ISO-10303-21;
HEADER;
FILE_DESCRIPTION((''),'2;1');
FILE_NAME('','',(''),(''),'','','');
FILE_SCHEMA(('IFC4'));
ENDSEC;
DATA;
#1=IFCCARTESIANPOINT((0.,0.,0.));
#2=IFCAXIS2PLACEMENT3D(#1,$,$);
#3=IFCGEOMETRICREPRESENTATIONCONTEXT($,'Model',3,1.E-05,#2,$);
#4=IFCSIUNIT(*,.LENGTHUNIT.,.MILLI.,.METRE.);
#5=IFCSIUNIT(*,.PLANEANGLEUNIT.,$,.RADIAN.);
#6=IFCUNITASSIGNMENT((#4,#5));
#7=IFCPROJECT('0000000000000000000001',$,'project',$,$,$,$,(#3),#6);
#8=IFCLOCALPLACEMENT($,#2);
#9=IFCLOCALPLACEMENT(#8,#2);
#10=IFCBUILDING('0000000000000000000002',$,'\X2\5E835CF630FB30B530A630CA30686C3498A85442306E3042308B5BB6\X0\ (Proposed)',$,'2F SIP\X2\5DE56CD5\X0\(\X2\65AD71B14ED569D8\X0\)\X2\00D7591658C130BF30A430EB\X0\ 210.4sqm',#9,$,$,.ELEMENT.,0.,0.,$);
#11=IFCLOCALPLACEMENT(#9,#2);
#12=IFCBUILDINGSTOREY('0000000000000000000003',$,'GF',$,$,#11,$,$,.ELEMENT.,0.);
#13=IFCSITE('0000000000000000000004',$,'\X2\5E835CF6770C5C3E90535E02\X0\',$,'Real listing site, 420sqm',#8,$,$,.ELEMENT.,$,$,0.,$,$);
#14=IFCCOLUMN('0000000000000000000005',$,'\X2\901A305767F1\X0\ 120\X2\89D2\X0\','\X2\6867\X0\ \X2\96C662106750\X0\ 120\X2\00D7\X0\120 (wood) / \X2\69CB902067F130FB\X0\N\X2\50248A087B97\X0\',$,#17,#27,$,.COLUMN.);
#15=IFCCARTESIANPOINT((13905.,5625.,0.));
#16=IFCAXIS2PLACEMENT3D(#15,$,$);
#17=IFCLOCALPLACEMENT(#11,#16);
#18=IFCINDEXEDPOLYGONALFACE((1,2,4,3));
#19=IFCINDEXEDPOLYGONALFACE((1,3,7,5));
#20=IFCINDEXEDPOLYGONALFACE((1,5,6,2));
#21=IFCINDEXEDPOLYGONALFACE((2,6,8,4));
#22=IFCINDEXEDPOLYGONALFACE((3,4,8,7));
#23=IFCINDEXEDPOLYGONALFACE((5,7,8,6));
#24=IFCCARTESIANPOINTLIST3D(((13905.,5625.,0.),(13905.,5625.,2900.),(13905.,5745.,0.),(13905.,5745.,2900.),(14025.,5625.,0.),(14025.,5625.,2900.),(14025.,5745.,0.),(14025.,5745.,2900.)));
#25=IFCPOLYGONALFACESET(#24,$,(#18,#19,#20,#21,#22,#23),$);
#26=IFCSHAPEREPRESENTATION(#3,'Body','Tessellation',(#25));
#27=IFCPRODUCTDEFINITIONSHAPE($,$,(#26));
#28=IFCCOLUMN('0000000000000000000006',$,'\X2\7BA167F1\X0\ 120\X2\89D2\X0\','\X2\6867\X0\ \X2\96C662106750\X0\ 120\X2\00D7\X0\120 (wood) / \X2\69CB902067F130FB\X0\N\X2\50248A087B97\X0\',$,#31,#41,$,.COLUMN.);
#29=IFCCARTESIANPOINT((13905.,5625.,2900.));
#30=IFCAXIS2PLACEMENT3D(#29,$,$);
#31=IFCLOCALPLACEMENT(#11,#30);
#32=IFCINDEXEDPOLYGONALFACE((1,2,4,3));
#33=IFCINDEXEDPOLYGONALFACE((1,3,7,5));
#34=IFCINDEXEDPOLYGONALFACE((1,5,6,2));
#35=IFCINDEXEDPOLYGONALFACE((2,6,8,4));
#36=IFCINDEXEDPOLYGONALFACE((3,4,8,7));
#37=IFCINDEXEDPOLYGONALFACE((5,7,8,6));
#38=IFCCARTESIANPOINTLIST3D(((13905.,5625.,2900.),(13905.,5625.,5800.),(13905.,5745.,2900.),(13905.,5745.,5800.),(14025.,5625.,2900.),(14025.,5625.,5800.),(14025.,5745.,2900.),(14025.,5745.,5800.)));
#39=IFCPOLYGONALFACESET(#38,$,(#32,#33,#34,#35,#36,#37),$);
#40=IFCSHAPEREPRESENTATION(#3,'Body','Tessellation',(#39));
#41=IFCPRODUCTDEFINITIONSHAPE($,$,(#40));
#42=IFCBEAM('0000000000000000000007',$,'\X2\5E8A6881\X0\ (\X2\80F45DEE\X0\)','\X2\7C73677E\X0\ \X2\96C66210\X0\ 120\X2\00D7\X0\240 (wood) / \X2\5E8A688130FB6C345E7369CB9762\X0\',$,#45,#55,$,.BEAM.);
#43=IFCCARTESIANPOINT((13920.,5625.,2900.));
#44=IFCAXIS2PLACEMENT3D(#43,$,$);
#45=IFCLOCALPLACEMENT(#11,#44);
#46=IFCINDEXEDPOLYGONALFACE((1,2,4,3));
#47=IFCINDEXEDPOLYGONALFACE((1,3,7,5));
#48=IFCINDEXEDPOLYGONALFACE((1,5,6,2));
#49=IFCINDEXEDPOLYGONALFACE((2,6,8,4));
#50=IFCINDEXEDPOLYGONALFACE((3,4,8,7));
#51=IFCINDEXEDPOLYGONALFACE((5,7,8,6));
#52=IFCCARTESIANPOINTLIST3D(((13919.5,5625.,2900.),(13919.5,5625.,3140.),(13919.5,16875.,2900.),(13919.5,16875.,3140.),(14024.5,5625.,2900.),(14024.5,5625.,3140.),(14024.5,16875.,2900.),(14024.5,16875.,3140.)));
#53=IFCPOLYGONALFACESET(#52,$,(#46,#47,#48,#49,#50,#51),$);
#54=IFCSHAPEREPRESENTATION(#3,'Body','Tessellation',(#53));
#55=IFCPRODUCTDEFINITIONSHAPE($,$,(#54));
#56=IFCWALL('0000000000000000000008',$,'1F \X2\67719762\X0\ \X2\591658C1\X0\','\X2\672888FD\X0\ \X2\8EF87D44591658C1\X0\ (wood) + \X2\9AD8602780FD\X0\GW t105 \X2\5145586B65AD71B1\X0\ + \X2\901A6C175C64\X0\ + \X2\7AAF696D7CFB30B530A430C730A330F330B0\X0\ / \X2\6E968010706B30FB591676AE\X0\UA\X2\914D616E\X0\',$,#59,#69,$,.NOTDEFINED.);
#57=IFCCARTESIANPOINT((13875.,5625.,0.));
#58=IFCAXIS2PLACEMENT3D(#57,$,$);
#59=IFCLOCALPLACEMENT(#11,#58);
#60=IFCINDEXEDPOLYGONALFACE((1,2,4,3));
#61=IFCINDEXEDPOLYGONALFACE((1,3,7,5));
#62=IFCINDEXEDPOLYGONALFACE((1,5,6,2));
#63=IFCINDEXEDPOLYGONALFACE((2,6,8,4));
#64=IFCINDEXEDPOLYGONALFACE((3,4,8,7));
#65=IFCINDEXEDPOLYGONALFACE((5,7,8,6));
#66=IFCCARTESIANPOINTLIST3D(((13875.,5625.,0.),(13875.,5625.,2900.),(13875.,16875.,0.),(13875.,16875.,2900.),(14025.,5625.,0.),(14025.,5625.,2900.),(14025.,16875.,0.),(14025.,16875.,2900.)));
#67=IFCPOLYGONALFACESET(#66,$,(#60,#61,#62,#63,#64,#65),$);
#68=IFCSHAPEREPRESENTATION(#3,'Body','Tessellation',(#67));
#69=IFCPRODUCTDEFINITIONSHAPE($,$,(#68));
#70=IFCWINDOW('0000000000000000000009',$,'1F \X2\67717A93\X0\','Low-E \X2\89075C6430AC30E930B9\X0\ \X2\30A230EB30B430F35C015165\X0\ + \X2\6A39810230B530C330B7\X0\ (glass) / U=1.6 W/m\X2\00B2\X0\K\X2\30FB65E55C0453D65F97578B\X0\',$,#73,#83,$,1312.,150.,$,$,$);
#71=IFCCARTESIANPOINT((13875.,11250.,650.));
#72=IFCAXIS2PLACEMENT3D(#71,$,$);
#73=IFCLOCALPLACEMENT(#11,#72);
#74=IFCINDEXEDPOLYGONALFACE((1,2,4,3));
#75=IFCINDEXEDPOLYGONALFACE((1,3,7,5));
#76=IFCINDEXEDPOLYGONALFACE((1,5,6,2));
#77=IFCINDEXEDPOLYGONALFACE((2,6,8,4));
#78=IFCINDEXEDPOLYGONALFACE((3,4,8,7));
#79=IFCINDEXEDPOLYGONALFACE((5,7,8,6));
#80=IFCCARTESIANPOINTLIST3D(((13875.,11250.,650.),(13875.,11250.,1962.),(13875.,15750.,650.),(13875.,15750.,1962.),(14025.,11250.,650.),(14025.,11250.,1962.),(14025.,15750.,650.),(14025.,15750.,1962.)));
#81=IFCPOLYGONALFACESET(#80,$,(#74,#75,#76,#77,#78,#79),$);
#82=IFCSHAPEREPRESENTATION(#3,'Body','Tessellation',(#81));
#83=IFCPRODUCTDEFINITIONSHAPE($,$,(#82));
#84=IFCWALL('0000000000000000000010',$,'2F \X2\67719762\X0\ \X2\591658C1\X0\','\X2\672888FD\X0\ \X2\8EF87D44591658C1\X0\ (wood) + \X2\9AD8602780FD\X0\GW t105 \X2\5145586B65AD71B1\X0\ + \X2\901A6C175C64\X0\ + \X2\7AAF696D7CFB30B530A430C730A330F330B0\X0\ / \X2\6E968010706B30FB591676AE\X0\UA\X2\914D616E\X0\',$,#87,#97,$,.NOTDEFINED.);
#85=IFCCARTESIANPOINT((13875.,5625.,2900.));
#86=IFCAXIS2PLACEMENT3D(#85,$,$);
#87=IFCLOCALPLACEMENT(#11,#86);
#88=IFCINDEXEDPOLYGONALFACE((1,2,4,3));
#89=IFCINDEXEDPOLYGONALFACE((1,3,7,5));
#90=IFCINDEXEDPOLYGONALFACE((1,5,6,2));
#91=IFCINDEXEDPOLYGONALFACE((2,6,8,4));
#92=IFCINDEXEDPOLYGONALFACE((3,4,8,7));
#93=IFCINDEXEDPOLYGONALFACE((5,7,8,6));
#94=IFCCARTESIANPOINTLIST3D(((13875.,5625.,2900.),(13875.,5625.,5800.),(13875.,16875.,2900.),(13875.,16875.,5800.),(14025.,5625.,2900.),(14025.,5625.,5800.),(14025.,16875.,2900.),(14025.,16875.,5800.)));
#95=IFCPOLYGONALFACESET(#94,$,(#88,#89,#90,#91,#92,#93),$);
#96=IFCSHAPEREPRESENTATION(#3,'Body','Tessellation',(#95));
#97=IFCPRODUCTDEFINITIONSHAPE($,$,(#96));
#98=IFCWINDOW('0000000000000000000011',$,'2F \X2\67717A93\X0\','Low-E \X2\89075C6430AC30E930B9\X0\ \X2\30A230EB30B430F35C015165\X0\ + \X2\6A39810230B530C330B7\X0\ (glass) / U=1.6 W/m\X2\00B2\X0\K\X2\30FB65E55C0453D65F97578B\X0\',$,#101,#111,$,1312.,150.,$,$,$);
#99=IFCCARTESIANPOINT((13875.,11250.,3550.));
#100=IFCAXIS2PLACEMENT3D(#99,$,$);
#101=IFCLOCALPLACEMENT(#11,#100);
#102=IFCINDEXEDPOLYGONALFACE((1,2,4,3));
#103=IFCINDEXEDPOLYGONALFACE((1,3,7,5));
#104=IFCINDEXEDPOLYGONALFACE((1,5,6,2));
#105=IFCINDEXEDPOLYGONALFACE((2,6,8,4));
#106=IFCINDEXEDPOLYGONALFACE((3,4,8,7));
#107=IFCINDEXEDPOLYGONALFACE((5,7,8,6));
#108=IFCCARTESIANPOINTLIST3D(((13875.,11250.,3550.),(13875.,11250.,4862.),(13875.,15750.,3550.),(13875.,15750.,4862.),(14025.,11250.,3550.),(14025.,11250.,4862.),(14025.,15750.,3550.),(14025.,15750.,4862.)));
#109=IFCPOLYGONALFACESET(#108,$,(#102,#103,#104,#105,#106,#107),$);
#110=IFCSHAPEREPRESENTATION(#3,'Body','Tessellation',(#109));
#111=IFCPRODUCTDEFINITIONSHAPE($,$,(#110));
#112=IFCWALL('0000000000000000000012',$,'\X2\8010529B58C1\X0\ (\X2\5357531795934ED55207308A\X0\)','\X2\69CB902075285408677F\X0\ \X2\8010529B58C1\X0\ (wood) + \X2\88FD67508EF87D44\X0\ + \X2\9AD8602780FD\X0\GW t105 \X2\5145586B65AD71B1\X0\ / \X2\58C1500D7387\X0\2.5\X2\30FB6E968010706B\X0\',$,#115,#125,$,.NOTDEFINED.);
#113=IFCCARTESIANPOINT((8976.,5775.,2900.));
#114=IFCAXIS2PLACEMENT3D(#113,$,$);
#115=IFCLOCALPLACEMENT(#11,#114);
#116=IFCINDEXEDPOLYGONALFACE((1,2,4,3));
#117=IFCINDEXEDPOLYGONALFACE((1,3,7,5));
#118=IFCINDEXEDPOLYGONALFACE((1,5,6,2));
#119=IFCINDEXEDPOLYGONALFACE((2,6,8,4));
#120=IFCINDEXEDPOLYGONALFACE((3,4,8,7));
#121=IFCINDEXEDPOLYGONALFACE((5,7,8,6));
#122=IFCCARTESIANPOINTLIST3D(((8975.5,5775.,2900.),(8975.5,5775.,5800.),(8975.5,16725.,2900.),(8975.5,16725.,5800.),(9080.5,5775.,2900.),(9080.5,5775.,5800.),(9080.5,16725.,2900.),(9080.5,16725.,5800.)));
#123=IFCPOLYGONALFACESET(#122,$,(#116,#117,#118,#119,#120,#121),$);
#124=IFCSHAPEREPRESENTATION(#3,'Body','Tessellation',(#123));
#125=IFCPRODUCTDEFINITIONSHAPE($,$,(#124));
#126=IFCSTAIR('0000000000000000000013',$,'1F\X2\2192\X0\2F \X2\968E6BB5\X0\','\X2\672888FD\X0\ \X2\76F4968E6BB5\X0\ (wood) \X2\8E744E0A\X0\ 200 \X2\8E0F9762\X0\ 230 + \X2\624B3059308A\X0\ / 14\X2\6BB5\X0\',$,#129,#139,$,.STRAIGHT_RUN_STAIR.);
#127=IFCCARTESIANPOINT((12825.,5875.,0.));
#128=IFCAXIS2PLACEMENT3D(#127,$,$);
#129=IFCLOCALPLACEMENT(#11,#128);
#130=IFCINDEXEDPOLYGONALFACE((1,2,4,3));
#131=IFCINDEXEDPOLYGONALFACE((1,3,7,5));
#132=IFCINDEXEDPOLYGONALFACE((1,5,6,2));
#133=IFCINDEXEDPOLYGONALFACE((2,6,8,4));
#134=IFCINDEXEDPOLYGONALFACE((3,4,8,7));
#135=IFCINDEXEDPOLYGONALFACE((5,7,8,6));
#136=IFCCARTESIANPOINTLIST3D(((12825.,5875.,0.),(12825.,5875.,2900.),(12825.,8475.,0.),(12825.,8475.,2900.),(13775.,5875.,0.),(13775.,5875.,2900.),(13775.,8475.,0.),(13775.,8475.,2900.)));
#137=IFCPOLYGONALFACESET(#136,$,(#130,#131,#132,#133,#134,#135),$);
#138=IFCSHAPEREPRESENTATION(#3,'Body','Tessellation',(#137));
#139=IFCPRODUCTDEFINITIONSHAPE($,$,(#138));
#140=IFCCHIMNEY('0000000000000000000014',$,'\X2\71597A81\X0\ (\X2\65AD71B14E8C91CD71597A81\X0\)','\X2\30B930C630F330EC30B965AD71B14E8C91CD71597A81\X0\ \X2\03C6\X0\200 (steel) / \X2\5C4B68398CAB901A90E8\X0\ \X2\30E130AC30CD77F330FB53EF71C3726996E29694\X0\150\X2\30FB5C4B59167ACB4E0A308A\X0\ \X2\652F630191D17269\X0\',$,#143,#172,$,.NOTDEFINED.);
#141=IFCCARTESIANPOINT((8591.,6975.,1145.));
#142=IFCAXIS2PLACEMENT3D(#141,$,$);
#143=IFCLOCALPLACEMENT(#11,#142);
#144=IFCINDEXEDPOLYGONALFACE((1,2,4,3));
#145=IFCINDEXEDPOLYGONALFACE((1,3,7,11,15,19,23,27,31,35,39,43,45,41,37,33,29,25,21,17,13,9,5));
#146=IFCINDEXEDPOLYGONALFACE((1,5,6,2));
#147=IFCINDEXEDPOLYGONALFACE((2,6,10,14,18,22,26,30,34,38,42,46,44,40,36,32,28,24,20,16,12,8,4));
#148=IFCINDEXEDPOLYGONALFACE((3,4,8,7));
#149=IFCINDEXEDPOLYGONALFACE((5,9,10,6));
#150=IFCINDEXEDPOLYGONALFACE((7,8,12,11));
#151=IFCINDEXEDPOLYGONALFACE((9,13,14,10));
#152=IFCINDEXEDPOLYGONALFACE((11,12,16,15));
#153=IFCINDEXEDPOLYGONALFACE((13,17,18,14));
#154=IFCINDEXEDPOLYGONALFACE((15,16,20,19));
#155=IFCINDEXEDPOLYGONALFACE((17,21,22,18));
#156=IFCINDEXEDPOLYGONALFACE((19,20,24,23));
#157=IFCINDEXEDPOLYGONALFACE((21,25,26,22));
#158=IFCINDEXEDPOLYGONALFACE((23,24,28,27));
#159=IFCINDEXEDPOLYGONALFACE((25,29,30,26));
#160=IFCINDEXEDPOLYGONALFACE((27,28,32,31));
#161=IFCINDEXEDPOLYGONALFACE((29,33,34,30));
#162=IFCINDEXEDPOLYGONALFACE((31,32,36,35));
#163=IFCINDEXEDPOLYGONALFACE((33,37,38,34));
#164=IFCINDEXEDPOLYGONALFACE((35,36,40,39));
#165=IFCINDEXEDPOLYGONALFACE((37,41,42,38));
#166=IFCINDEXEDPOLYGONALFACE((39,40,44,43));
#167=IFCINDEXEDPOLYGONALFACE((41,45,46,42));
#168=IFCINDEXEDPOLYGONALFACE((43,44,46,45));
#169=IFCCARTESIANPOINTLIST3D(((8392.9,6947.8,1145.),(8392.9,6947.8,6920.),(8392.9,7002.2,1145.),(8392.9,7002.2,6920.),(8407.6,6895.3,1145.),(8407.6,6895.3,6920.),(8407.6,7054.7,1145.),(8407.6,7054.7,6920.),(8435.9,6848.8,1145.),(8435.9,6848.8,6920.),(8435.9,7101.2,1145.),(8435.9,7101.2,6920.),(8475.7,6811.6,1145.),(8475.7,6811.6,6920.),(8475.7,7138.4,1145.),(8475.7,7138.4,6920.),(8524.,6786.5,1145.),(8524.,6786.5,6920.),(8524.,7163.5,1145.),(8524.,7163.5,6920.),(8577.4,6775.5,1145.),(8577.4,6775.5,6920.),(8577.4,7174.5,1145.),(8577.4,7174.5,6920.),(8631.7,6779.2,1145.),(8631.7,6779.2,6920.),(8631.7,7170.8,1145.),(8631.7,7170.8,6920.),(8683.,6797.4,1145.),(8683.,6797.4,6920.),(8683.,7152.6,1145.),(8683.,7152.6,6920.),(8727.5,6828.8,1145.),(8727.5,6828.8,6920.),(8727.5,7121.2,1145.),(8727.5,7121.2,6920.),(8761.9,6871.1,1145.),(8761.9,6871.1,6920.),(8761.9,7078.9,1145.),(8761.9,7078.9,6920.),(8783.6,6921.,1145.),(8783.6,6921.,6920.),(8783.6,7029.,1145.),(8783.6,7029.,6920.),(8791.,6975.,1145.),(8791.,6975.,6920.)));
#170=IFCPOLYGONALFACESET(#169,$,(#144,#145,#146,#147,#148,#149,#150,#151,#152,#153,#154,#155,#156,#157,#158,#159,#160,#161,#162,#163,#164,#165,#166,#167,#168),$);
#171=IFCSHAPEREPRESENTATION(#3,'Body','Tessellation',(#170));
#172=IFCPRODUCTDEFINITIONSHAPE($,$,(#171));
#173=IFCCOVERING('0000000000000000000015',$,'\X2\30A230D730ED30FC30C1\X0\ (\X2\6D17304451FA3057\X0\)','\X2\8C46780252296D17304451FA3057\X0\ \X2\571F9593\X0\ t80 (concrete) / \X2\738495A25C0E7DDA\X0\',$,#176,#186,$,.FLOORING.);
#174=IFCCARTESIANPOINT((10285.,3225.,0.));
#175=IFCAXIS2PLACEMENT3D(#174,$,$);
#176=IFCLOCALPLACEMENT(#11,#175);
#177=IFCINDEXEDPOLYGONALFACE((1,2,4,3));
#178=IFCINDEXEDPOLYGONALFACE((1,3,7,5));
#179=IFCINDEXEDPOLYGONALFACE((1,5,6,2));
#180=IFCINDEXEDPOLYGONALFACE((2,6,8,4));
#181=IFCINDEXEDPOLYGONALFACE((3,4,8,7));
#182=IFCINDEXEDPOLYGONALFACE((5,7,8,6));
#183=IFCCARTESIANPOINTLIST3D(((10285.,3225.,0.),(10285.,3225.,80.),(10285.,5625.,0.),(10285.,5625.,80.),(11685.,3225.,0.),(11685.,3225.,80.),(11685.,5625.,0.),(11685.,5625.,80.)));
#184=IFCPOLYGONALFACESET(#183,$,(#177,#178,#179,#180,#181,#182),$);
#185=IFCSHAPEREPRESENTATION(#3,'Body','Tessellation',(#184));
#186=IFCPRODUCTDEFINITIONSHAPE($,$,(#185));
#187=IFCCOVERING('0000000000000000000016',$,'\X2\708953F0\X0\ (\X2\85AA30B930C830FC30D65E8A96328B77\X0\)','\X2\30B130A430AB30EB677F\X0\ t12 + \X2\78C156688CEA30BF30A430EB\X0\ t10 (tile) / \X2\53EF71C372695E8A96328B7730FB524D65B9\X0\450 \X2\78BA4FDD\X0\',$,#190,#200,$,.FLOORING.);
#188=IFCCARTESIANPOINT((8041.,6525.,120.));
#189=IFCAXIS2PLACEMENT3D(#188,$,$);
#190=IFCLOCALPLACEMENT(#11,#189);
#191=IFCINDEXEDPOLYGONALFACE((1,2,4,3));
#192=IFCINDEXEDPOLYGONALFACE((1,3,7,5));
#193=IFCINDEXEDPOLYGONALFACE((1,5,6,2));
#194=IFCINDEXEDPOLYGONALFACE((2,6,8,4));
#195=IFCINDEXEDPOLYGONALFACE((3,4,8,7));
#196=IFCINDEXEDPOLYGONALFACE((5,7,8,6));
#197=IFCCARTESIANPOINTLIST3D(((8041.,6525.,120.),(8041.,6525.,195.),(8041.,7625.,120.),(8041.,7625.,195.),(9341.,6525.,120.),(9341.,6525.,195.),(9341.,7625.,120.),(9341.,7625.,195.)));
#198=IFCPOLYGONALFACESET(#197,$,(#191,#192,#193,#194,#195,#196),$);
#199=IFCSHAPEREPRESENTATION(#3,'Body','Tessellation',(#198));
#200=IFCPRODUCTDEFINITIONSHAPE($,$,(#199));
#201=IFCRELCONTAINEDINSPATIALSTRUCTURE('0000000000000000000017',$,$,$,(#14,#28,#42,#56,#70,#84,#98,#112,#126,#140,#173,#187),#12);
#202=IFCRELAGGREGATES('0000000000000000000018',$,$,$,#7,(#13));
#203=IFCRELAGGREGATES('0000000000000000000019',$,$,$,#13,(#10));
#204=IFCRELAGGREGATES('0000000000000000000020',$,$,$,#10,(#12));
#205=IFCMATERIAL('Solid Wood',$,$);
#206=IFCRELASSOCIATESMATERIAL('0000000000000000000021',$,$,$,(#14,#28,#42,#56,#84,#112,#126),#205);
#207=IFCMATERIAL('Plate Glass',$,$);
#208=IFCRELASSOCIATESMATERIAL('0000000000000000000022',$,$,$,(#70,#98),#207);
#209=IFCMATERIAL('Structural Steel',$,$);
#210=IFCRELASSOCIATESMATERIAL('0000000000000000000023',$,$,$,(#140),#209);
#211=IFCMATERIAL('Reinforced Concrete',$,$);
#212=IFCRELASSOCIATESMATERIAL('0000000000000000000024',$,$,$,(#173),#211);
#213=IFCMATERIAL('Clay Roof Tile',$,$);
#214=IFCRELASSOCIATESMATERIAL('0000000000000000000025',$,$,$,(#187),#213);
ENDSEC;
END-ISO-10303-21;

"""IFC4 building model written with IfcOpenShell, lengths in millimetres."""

from ifc_helpers import new_model, si_unit, frame, frame_2d, origin, origin_2d, place, context, project, spatial, rectangle, circle, extrude, material, element, fill, save


model = new_model("IFC4")

# Units and contexts
model_context = context("Model", 3, precision=1e-05, world=origin())
ifc_project = project(units=[si_unit("LENGTHUNIT", "METRE", prefix="MILLI"), si_unit("PLANEANGLEUNIT", "RADIAN")], contexts=[model_context])

# Site, building, storey
site_placement = place(None, origin())
site = spatial("IfcSite", under=ifc_project, at=site_placement, Name="広島県尾道市", ObjectType="Real listing site, 420sqm", CompositionType="ELEMENT", RefElevation=0.0)
building_placement = place(site_placement, origin())
building = spatial("IfcBuilding", under=site, at=building_placement, Name="広島・サウナと水風呂のある家 (Proposed)", ObjectType="2F SIP工法(断熱仕様)×外壁タイル 210.4sqm", CompositionType="ELEMENT", ElevationOfRefHeight=0.0, ElevationOfTerrain=0.0)
storey_placement = place(building_placement, origin())
storey = spatial("IfcBuildingStorey", under=building, at=storey_placement, Name="GF", CompositionType="ELEMENT", Elevation=0.0)

# Columns
ifc_material_1 = material(Name="Solid Wood")
column_1_placement = place(storey_placement, frame((13905.0, 5625.0, 0.0)))
element("IfcColumn", 1, at=column_1_placement, inside=storey, material=ifc_material_1, Name="通し柱 120角", Description="桧 集成材 120×120 (wood) / 構造柱・N値計算", PredefinedType="COLUMN", context=model_context, shape_type="SweptSolid", body=[
    extrude(rectangle(XDim=120.0, YDim=120.0, at=frame_2d((60.0, 60.0))), frame((13905.0, 5625.0, 0.0)), (0.0, 0.0, 1.0), 2900.0),
])
column_2_placement = place(storey_placement, frame((13905.0, 5625.0, 2900.0)))
element("IfcColumn", 2, at=column_2_placement, inside=storey, material=ifc_material_1, Name="管柱 120角", Description="桧 集成材 120×120 (wood) / 構造柱・N値計算", PredefinedType="COLUMN", context=model_context, shape_type="SweptSolid", body=[
    extrude(rectangle(XDim=120.0, YDim=120.0, at=frame_2d((60.0, 60.0))), frame((13905.0, 5625.0, 2900.0)), (0.0, 0.0, 1.0), 2900.0),
])

# Beam
beam_1_placement = place(storey_placement, frame((13920.0, 5625.0, 2900.0)))
element("IfcBeam", 3, at=beam_1_placement, inside=storey, material=ifc_material_1, Name="床梁 (胴差)", Description="米松 集成 120×240 (wood) / 床梁・水平構面", PredefinedType="BEAM", context=model_context, shape_type="SweptSolid", body=[
    extrude(rectangle(XDim=105.0, YDim=11250.0, at=frame_2d((52.0, 5625.0))), frame((13920.0, 5625.0, 2900.0)), (0.0, 0.0, 1.0), 240.0),
])

# Wall, opening, window
wall_1_placement = place(storey_placement, frame((13875.0, 5625.0, 0.0)))
wall_1 = element("IfcWall", 4, at=wall_1_placement, inside=storey, material=ifc_material_1, Name="1F 東面 外壁", Description="木製 軸組外壁 (wood) + 高性能GW t105 充填断熱 + 通気層 + 窯業系サイディング / 準耐火・外皮UA配慮", PredefinedType="NOTDEFINED", context=model_context, shape_type="SweptSolid", body=[
    extrude(rectangle(XDim=150.0, YDim=11250.0, at=frame_2d((75.0, 5625.0))), frame((13875.0, 5625.0, 0.0)), (0.0, 0.0, 1.0), 2900.0),
])
opening_1_placement = place(storey_placement, frame((13875.0, 11250.0, 650.0)))
opening_1 = element("IfcOpeningElement", 5, at=opening_1_placement, cuts=wall_1, PredefinedType="NOTDEFINED", context=model_context, shape_type="SweptSolid", body=[
    extrude(rectangle(XDim=150.0, YDim=4500.0, at=frame_2d((75.0, 2250.0))), frame((13875.0, 11250.0, 650.0)), (0.0, 0.0, 1.0), 1312.0),
])
ifc_material_2 = material(Name="Plate Glass")
window_1_placement = place(storey_placement, frame((13875.0, 11250.0, 650.0)))
window_1 = element("IfcWindow", 6, at=window_1_placement, inside=storey, material=ifc_material_2, Name="1F 東窓", Description="Low-E 複層ガラス アルゴン封入 + 樹脂サッシ (glass) / U=1.6 W/m²K・日射取得型", OverallHeight=1312.0, OverallWidth=150.0, context=model_context, shape_type="SweptSolid", body=[
    extrude(rectangle(XDim=150.0, YDim=4500.0, at=frame_2d((75.0, 2250.0))), frame((13875.0, 11250.0, 650.0)), (0.0, 0.0, 1.0), 1312.0),
])
fill(opening_1, window_1)

# Wall, opening, window
wall_2_placement = place(storey_placement, frame((13875.0, 5625.0, 2900.0)))
wall_2 = element("IfcWall", 7, at=wall_2_placement, inside=storey, material=ifc_material_1, Name="2F 東面 外壁", Description="木製 軸組外壁 (wood) + 高性能GW t105 充填断熱 + 通気層 + 窯業系サイディング / 準耐火・外皮UA配慮", PredefinedType="NOTDEFINED", context=model_context, shape_type="SweptSolid", body=[
    extrude(rectangle(XDim=150.0, YDim=11250.0, at=frame_2d((75.0, 5625.0))), frame((13875.0, 5625.0, 2900.0)), (0.0, 0.0, 1.0), 2900.0),
])
opening_2_placement = place(storey_placement, frame((13875.0, 11250.0, 3550.0)))
opening_2 = element("IfcOpeningElement", 8, at=opening_2_placement, cuts=wall_2, PredefinedType="NOTDEFINED", context=model_context, shape_type="SweptSolid", body=[
    extrude(rectangle(XDim=150.0, YDim=4500.0, at=frame_2d((75.0, 2250.0))), frame((13875.0, 11250.0, 3550.0)), (0.0, 0.0, 1.0), 1312.0),
])
window_2_placement = place(storey_placement, frame((13875.0, 11250.0, 3550.0)))
window_2 = element("IfcWindow", 9, at=window_2_placement, inside=storey, material=ifc_material_2, Name="2F 東窓", Description="Low-E 複層ガラス アルゴン封入 + 樹脂サッシ (glass) / U=1.6 W/m²K・日射取得型", OverallHeight=1312.0, OverallWidth=150.0, context=model_context, shape_type="SweptSolid", body=[
    extrude(rectangle(XDim=150.0, YDim=4500.0, at=frame_2d((75.0, 2250.0))), frame((13875.0, 11250.0, 3550.0)), (0.0, 0.0, 1.0), 1312.0),
])
fill(opening_2, window_2)

# Wall
wall_3_placement = place(storey_placement, frame((8976.0, 5775.0, 2900.0)))
element("IfcWall", 10, at=wall_3_placement, inside=storey, material=ifc_material_1, Name="耐力壁 (南北間仕切り)", Description="構造用合板 耐力壁 (wood) + 製材軸組 + 高性能GW t105 充填断熱 / 壁倍率2.5・準耐火", PredefinedType="NOTDEFINED", context=model_context, shape_type="SweptSolid", body=[
    extrude(rectangle(XDim=105.0, YDim=10950.0, at=frame_2d((52.0, 5475.0))), frame((8976.0, 5775.0, 2900.0)), (0.0, 0.0, 1.0), 2900.0),
])

# Stair
stair_placement = place(storey_placement, frame((12825.0, 5875.0, 0.0)))
element("IfcStair", 11, at=stair_placement, inside=storey, material=ifc_material_1, Name="1F→2F 階段", Description="木製 直階段 (wood) 蹴上 200 踏面 230 + 手すり / 14段", PredefinedType="STRAIGHT_RUN_STAIR", context=model_context, shape_type="SweptSolid", body=[
    extrude(rectangle(XDim=950.0, YDim=2600.0, at=frame_2d((475.0, 1300.0))), frame((12825.0, 5875.0, 0.0)), (0.0, 0.0, 1.0), 2900.0),
])

# Chimney
ifc_material_3 = material(Name="Structural Steel")
chimney_placement = place(storey_placement, frame((8591.0, 6975.0, 1145.0)))
element("IfcChimney", 12, at=chimney_placement, inside=storey, material=ifc_material_3, Name="煙突 (断熱二重煙突)", Description="ステンレス断熱二重煙突 φ200 (steel) / 屋根貫通部 メガネ石・可燃物離隔150・屋外立上り 支持金物", PredefinedType="NOTDEFINED", context=model_context, shape_type="SweptSolid", body=[
    extrude(circle(Radius=200.0, at=origin_2d()), frame((8591.0, 6975.0, 1145.0)), (0.0, 0.0, 1.0), 5775.0),
])

# Coverings
ifc_material_4 = material(Name="Reinforced Concrete")
covering_1_placement = place(storey_placement, frame((10285.0, 3225.0, 0.0)))
element("IfcCovering", 13, at=covering_1_placement, inside=storey, material=ifc_material_4, Name="アプローチ (洗い出し)", Description="豆砂利洗い出し 土間 t80 (concrete) / 玄関導線", PredefinedType="FLOORING", context=model_context, shape_type="SweptSolid", body=[
    extrude(rectangle(XDim=1400.0, YDim=2400.0, at=frame_2d((700.0, 1200.0))), frame((10285.0, 3225.0, 0.0)), (0.0, 0.0, 1.0), 80.0),
])
ifc_material_5 = material(Name="Clay Roof Tile")
covering_2_placement = place(storey_placement, frame((8041.0, 6525.0, 120.0)))
element("IfcCovering", 14, at=covering_2_placement, inside=storey, material=ifc_material_5, Name="炉台 (薪ストーブ床防護)", Description="ケイカル板 t12 + 磁器質タイル t10 (tile) / 可燃物床防護・前方450 確保", PredefinedType="FLOORING", context=model_context, shape_type="SweptSolid", body=[
    extrude(rectangle(XDim=1300.0, YDim=1100.0, at=frame_2d((650.0, 550.0))), frame((8041.0, 6525.0, 120.0)), (0.0, 0.0, 1.0), 75.0),
])

save(model, "model.ifc")
